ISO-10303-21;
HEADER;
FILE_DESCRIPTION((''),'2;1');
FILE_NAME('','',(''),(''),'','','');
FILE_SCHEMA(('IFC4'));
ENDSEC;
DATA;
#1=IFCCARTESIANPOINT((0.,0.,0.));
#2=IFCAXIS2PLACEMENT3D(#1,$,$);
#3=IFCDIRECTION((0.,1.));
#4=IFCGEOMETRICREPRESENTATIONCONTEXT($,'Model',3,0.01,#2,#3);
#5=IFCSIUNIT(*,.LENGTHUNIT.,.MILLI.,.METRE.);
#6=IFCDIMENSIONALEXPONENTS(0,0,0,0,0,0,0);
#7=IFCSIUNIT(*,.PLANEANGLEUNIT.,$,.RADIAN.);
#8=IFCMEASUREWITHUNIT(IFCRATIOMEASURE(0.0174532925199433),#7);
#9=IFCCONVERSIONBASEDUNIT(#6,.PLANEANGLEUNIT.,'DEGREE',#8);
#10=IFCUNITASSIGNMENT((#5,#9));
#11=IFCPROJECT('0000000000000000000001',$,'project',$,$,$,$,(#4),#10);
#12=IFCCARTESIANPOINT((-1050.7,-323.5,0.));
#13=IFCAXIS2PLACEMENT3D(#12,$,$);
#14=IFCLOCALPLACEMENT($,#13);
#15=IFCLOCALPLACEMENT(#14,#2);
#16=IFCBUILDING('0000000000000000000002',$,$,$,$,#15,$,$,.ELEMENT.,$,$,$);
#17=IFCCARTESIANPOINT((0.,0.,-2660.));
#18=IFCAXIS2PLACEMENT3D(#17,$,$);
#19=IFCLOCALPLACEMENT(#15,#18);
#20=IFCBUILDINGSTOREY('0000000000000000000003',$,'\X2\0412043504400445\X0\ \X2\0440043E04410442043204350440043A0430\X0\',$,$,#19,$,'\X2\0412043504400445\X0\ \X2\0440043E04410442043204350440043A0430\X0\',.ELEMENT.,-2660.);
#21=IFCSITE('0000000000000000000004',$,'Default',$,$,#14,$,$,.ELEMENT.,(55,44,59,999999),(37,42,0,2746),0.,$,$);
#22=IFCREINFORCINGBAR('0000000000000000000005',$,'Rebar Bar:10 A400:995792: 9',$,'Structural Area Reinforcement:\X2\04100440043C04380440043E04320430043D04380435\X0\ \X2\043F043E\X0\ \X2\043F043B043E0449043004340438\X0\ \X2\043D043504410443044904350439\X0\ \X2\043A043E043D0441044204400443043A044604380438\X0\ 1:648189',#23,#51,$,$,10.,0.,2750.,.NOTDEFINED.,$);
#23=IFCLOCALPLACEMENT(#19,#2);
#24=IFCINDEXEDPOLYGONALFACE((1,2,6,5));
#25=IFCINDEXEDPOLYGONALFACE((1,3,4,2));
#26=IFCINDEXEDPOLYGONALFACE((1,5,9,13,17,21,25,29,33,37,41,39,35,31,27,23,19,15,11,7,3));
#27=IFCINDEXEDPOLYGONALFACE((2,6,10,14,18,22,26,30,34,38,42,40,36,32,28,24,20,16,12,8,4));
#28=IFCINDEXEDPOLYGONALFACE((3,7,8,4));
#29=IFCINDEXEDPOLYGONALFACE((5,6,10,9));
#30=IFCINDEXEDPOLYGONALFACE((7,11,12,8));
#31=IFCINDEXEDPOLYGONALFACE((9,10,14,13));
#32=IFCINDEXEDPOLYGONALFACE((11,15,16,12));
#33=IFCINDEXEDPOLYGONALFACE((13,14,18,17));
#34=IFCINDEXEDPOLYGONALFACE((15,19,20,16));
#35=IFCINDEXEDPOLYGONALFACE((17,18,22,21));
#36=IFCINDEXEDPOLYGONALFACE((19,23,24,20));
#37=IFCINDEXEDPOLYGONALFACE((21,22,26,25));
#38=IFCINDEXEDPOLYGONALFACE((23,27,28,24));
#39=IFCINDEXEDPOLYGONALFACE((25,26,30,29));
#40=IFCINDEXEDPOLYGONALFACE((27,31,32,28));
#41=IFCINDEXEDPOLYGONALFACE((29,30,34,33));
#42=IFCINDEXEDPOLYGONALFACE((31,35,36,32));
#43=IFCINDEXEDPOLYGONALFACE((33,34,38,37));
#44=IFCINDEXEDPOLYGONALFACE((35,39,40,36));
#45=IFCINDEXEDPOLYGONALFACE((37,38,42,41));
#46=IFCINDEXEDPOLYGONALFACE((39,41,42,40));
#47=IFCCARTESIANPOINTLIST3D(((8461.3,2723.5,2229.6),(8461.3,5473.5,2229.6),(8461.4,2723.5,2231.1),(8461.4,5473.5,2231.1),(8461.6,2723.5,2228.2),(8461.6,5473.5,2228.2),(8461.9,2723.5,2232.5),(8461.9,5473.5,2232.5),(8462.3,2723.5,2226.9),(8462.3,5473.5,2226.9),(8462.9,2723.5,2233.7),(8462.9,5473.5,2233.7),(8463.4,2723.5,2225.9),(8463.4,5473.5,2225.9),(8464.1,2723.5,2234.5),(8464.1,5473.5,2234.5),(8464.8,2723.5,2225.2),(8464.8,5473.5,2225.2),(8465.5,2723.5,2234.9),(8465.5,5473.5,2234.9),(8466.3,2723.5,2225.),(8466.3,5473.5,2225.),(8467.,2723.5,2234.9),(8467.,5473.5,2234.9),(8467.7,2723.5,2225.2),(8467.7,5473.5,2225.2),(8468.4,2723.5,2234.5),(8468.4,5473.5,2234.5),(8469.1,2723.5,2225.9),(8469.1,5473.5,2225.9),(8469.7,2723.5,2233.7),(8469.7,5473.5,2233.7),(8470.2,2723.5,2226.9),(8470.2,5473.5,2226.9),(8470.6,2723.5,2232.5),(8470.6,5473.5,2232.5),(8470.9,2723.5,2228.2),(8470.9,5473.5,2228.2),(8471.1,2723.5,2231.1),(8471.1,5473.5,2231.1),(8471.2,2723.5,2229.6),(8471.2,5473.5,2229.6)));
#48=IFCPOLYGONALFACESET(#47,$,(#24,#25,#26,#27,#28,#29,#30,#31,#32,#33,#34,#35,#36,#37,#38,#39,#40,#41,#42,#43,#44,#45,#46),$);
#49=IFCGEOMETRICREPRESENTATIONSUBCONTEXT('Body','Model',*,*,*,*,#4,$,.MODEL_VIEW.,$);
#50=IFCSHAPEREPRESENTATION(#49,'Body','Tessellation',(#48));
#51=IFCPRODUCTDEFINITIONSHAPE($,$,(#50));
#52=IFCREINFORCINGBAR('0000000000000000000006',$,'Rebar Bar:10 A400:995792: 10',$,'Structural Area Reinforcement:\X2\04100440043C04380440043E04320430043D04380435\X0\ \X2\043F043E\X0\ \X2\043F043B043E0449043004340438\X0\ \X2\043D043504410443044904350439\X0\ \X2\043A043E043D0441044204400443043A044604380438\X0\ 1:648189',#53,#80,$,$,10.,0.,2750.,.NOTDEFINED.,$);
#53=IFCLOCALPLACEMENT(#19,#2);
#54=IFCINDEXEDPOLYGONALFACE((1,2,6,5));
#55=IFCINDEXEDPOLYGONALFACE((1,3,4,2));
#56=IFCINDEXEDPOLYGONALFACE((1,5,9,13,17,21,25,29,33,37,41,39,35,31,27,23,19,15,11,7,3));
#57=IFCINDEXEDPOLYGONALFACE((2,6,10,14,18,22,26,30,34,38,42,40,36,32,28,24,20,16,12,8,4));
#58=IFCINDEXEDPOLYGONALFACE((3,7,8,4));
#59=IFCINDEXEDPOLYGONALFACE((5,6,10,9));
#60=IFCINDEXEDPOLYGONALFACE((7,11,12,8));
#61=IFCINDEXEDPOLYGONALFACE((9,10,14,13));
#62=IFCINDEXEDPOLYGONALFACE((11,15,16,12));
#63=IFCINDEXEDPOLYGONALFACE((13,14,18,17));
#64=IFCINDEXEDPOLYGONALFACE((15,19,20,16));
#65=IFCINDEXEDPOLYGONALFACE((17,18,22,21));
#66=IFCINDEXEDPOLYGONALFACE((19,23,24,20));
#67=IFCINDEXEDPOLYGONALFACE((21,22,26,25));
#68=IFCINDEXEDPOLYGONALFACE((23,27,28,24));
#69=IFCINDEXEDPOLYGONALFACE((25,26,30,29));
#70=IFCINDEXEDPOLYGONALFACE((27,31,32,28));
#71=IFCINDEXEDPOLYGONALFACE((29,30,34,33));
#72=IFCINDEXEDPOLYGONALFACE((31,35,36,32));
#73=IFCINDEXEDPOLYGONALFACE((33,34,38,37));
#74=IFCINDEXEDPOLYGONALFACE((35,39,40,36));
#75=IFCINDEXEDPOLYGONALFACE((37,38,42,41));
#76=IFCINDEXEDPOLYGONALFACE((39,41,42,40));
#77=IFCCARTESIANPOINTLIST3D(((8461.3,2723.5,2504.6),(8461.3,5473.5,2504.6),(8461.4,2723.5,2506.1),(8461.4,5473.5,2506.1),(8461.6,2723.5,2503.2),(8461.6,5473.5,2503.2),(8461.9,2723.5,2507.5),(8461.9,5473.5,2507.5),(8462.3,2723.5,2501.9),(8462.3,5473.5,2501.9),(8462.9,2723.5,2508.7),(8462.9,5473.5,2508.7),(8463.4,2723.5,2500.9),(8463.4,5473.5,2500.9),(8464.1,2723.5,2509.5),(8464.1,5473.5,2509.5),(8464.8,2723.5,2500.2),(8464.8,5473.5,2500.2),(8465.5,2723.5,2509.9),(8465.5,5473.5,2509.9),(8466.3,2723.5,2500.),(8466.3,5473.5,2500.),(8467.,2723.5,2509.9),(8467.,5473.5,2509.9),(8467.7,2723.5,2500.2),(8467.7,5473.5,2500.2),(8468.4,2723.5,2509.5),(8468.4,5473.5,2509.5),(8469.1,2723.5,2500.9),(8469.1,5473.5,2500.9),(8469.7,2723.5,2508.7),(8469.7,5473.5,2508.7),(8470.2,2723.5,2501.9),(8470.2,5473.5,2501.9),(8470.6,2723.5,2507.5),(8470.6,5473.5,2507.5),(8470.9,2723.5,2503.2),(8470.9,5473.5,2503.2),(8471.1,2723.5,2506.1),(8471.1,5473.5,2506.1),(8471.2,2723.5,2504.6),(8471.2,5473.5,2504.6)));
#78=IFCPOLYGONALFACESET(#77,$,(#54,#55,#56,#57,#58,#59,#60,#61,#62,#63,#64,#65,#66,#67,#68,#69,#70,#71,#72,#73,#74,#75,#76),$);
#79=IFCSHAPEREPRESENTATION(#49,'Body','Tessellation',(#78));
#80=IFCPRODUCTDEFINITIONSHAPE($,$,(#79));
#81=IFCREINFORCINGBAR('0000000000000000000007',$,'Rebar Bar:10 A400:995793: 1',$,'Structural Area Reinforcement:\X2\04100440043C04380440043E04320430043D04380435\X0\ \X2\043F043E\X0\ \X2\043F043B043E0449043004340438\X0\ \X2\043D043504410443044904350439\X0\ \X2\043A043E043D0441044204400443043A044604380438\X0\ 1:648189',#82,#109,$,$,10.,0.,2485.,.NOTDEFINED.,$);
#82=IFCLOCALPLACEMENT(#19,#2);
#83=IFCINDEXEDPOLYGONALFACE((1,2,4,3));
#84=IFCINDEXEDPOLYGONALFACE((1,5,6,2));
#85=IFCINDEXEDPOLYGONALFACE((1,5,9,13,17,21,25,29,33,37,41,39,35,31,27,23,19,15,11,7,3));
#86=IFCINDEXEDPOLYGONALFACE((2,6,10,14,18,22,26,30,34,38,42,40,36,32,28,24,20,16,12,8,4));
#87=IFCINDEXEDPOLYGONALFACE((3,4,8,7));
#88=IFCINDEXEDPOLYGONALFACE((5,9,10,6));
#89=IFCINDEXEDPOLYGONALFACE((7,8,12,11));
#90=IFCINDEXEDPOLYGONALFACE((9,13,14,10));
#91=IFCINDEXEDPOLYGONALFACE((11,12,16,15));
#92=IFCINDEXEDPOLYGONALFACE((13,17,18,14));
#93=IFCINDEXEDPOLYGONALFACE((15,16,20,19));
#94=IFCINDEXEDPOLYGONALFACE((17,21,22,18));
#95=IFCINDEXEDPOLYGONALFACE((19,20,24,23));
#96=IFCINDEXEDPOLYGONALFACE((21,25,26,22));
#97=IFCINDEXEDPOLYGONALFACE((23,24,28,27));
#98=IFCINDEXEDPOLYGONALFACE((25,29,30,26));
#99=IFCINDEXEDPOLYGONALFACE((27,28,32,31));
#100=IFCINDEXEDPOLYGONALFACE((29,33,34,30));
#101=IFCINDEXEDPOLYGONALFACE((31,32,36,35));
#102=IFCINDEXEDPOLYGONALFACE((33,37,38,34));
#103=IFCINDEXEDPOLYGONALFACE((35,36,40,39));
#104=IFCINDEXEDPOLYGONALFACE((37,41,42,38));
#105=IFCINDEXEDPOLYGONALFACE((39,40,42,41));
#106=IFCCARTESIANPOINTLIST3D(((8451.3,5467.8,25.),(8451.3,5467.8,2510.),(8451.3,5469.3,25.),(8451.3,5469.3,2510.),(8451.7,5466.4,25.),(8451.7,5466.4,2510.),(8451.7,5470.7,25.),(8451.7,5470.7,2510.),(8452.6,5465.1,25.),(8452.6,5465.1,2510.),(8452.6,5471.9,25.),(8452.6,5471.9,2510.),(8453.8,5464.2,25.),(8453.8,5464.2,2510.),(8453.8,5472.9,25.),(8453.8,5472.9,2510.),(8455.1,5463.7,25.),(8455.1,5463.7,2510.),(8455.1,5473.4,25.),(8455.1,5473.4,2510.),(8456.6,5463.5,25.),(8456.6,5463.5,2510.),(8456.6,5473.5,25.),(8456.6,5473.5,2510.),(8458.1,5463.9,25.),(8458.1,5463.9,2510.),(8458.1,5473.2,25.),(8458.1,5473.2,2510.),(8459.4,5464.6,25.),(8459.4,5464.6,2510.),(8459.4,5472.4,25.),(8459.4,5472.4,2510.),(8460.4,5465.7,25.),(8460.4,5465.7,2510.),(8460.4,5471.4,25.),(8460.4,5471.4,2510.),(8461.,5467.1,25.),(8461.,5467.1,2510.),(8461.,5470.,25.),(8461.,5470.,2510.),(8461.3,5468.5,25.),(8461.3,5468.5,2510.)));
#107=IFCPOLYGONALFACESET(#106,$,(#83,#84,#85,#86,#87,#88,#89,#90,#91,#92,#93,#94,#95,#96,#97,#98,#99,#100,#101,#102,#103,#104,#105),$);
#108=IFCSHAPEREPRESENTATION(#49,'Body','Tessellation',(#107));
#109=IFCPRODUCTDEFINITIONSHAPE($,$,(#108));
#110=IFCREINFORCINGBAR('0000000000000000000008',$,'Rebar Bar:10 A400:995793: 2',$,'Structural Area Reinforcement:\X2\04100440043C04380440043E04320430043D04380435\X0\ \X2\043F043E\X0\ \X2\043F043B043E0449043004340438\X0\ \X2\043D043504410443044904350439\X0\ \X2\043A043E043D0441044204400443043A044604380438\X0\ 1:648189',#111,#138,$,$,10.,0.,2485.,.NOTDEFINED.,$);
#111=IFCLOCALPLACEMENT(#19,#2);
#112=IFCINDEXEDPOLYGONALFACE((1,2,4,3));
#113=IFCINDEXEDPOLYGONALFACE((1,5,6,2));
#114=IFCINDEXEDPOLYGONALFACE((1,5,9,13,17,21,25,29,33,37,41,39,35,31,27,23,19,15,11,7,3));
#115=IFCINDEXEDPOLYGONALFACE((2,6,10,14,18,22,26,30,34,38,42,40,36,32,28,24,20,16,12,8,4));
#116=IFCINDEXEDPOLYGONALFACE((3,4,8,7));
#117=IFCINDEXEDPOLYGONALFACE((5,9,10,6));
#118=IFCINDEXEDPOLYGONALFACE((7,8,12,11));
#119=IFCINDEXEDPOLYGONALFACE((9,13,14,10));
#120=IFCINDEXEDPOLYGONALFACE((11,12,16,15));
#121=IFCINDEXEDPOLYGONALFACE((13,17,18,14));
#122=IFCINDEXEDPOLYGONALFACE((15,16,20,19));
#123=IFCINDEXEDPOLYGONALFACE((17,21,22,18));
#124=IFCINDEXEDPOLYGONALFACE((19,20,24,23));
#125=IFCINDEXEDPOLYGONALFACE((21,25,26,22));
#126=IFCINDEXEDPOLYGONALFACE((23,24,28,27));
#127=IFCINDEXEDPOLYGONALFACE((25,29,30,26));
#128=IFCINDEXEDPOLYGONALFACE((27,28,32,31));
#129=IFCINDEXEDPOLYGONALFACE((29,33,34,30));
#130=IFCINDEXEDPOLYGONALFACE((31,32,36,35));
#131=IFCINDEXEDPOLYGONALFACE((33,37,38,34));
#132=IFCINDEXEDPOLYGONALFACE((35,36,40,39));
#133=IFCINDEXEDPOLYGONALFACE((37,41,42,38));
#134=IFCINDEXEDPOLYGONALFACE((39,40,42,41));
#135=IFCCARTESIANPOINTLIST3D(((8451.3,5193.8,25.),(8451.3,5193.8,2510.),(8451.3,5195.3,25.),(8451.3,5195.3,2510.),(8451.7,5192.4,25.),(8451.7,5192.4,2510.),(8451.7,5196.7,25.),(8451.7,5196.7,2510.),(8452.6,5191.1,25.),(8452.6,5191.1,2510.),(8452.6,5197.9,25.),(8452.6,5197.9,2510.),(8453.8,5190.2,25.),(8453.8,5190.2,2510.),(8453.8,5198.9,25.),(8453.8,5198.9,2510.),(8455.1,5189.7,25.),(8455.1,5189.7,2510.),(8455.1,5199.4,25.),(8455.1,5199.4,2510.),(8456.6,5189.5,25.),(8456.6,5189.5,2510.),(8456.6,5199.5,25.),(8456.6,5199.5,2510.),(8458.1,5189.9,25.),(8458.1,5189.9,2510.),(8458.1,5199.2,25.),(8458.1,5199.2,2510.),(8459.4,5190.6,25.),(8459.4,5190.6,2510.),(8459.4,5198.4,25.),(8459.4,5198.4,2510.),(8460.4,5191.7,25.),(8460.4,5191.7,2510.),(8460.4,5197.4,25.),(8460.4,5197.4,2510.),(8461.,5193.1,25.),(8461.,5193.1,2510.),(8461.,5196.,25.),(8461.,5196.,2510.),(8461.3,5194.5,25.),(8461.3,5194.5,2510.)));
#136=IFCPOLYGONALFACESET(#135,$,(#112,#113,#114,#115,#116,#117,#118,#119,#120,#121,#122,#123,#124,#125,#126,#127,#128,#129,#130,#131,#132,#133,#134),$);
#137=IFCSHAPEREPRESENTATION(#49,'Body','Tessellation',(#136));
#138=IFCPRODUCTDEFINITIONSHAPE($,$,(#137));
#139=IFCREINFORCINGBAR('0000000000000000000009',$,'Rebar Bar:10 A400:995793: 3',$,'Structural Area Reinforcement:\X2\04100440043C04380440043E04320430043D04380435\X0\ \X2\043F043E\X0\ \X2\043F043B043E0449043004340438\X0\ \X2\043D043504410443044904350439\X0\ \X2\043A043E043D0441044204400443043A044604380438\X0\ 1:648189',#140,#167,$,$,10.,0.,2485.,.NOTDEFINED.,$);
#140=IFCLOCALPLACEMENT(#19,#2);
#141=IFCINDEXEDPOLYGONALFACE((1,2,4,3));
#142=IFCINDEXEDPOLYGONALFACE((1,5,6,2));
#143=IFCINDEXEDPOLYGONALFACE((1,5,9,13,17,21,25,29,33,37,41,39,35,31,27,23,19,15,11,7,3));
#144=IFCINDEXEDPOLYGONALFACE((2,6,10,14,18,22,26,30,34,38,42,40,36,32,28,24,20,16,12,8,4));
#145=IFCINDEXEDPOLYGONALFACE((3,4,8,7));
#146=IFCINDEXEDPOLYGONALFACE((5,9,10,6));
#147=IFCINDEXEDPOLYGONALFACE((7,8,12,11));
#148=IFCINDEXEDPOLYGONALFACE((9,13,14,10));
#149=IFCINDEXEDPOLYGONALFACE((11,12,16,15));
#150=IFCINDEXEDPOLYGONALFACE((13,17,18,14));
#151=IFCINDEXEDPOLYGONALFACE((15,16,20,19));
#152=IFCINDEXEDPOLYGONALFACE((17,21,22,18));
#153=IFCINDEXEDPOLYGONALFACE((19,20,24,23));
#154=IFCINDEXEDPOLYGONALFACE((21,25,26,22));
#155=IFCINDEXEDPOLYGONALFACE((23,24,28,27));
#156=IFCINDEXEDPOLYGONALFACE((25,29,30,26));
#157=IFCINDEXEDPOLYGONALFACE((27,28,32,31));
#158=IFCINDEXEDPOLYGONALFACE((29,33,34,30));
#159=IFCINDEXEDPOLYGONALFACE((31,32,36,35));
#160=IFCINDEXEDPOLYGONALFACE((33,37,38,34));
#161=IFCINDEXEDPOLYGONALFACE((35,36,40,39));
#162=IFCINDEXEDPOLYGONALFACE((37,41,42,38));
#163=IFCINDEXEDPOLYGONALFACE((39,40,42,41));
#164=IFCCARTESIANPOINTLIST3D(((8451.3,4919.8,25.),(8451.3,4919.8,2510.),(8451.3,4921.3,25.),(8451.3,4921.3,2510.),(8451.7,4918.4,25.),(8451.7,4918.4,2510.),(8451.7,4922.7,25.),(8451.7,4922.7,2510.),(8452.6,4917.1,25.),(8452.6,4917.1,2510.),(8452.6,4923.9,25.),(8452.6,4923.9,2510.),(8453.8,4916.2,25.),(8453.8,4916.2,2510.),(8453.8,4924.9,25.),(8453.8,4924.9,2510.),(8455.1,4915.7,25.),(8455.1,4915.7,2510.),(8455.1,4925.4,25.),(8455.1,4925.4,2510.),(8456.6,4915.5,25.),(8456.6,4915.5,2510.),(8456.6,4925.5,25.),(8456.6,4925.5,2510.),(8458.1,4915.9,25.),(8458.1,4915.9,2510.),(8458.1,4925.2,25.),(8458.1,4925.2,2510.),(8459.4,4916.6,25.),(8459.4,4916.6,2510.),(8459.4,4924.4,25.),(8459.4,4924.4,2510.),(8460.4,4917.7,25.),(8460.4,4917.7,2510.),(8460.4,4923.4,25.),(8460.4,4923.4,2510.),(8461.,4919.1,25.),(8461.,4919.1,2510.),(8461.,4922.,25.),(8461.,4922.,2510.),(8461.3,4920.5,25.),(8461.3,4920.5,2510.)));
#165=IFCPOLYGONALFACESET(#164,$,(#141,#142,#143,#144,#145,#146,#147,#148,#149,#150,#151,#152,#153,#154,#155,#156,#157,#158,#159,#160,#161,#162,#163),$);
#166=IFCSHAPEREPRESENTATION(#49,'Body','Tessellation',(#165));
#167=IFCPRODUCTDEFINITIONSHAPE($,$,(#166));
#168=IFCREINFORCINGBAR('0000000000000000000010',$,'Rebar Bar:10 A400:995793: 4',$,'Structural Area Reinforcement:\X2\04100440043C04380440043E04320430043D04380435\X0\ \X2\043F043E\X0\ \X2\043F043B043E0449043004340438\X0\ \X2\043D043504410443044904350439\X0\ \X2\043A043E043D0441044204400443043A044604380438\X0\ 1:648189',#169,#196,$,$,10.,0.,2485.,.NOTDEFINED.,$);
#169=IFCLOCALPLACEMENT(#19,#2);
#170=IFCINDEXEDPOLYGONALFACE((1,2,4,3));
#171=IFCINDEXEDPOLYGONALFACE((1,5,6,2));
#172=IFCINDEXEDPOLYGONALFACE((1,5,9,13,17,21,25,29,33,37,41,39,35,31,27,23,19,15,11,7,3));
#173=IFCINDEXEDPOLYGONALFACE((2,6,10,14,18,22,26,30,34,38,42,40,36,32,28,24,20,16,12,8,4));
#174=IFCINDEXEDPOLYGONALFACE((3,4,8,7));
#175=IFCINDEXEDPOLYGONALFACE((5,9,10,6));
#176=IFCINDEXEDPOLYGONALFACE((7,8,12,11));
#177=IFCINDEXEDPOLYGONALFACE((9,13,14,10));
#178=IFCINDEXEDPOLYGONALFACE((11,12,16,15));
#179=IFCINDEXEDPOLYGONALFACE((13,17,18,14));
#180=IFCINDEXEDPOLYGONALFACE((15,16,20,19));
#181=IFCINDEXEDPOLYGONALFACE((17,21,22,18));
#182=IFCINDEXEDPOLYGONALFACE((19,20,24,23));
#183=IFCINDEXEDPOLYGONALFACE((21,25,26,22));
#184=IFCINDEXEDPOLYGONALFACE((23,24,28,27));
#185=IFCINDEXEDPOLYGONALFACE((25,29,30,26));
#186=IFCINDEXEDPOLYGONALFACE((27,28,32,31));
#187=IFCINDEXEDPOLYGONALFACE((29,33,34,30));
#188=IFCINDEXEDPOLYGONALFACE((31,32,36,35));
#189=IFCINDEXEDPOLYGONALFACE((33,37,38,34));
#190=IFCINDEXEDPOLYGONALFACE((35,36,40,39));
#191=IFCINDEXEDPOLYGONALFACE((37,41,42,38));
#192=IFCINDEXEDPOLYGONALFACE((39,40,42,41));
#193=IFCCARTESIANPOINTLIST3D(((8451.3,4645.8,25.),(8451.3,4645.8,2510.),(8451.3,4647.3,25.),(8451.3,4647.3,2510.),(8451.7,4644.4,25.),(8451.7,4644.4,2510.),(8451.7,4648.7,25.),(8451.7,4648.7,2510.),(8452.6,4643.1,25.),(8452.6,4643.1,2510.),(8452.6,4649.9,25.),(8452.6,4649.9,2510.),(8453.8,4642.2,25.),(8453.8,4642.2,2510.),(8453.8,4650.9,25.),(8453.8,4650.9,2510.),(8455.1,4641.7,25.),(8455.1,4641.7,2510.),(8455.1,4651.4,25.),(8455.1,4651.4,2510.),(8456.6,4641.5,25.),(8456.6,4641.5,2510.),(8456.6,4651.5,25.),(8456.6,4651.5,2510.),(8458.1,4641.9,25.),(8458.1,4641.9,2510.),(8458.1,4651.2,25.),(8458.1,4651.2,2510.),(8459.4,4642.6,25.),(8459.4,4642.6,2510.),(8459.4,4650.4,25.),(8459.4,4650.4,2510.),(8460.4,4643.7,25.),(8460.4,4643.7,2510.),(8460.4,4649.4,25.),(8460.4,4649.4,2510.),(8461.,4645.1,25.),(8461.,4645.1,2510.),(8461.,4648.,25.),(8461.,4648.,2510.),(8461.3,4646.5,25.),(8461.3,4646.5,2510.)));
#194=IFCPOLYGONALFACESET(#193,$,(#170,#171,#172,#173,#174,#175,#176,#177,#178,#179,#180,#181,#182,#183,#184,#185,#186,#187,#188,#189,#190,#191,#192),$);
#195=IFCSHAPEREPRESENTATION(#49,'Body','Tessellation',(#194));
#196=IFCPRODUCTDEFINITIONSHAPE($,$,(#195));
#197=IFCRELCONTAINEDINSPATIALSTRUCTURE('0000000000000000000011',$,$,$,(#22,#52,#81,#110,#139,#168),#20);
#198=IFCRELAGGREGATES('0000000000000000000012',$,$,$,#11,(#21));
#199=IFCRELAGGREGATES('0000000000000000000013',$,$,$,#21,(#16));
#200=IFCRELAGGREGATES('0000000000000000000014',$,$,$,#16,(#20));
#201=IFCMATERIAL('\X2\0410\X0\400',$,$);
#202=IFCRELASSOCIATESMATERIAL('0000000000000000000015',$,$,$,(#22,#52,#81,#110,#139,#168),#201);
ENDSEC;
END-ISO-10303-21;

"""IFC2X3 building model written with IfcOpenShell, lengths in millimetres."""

from ifc_helpers import new_model, entity, si_unit, converted_unit, direction, frame, origin, place, context, subcontext, project, spatial, material, element, save


model = new_model("IFC2X3")

# Units and contexts
model_context = context("Model", 3, precision=0.01, world=origin(), true_north=direction((0.0, 1.0)))
body_context = subcontext(model_context, "Body", "Model", "MODEL_VIEW")
ifc_project = project(units=[si_unit("LENGTHUNIT", "METRE", prefix="MILLI"), converted_unit("PLANEANGLEUNIT", "DEGREE", entity("IfcRatioMeasure", 0.0174532925199433), si_unit("PLANEANGLEUNIT", "RADIAN"), dimensions=[0, 0, 0, 0, 0, 0, 0])], contexts=[model_context])

# Site, building, storey
site_placement = place(None, frame((-1050.7, -323.5, 0.0)))
site = spatial("IfcSite", under=ifc_project, at=site_placement, Name="Default", CompositionType="ELEMENT", RefLatitude=(55, 44, 59, 999999), RefLongitude=(37, 42, 0, 2746), RefElevation=0.0)
building_placement = place(site_placement, origin())
building = spatial("IfcBuilding", under=site, at=building_placement, CompositionType="ELEMENT")
storey_placement = place(building_placement, frame((0.0, 0.0, -2660.0)))
storey = spatial("IfcBuildingStorey", under=building, at=storey_placement, Name="Верх ростверка", LongName="Верх ростверка", CompositionType="ELEMENT", Elevation=-2660.0)

# Reinforcing bars
ifc_material = material(Name="А400")
reinforcing_bar_1_placement = place(storey_placement, origin())
element("IfcReinforcingBar", 1, at=reinforcing_bar_1_placement, inside=storey, material=ifc_material, Name="Rebar Bar:10 A400:995792: 9", ObjectType="Structural Area Reinforcement:Армирование по площади несущей конструкции 1:648189", BarLength=2750.0, BarRole="NOTDEFINED", CrossSectionArea=0.0, NominalDiameter=10.0, context=body_context, shape_type="AdvancedSweptSolid", body=[
    entity("IfcSweptDiskSolid", entity("IfcCompositeCurve", [entity("IfcCompositeCurveSegment", "CONTINUOUS", True, entity("IfcPolyline", [entity("IfcCartesianPoint", [8466.3, 5473.5, 2230.0]), entity("IfcCartesianPoint", [8466.3, 2723.5, 2230.0])]))], False), 5.0, None, 0.0, 1.0),
])
reinforcing_bar_2_placement = place(storey_placement, origin())
element("IfcReinforcingBar", 2, at=reinforcing_bar_2_placement, inside=storey, material=ifc_material, Name="Rebar Bar:10 A400:995792: 10", ObjectType="Structural Area Reinforcement:Армирование по площади несущей конструкции 1:648189", BarLength=2750.0, BarRole="NOTDEFINED", CrossSectionArea=0.0, NominalDiameter=10.0, context=body_context, shape_type="AdvancedSweptSolid", body=[
    entity("IfcSweptDiskSolid", entity("IfcCompositeCurve", [entity("IfcCompositeCurveSegment", "CONTINUOUS", True, entity("IfcPolyline", [entity("IfcCartesianPoint", [8466.3, 5473.5, 2505.0]), entity("IfcCartesianPoint", [8466.3, 2723.5, 2505.0])]))], False), 5.0, None, 0.0, 1.0),
])
reinforcing_bar_3_placement = place(storey_placement, origin())
element("IfcReinforcingBar", 3, at=reinforcing_bar_3_placement, inside=storey, material=ifc_material, Name="Rebar Bar:10 A400:995793: 1", ObjectType="Structural Area Reinforcement:Армирование по площади несущей конструкции 1:648189", BarLength=2485.0, BarRole="NOTDEFINED", CrossSectionArea=0.0, NominalDiameter=10.0, context=body_context, shape_type="AdvancedSweptSolid", body=[
    entity("IfcSweptDiskSolid", entity("IfcCompositeCurve", [entity("IfcCompositeCurveSegment", "CONTINUOUS", True, entity("IfcPolyline", [entity("IfcCartesianPoint", [8456.3, 5468.5, 25.0]), entity("IfcCartesianPoint", [8456.3, 5468.5, 2510.0])]))], False), 5.0, None, 0.0, 1.0),
])
reinforcing_bar_4_placement = place(storey_placement, origin())
element("IfcReinforcingBar", 4, at=reinforcing_bar_4_placement, inside=storey, material=ifc_material, Name="Rebar Bar:10 A400:995793: 2", ObjectType="Structural Area Reinforcement:Армирование по площади несущей конструкции 1:648189", BarLength=2485.0, BarRole="NOTDEFINED", CrossSectionArea=0.0, NominalDiameter=10.0, context=body_context, shape_type="AdvancedSweptSolid", body=[
    entity("IfcSweptDiskSolid", entity("IfcCompositeCurve", [entity("IfcCompositeCurveSegment", "CONTINUOUS", True, entity("IfcPolyline", [entity("IfcCartesianPoint", [8456.3, 5194.5, 25.0]), entity("IfcCartesianPoint", [8456.3, 5194.5, 2510.0])]))], False), 5.0, None, 0.0, 1.0),
])
reinforcing_bar_5_placement = place(storey_placement, origin())
element("IfcReinforcingBar", 5, at=reinforcing_bar_5_placement, inside=storey, material=ifc_material, Name="Rebar Bar:10 A400:995793: 3", ObjectType="Structural Area Reinforcement:Армирование по площади несущей конструкции 1:648189", BarLength=2485.0, BarRole="NOTDEFINED", CrossSectionArea=0.0, NominalDiameter=10.0, context=body_context, shape_type="AdvancedSweptSolid", body=[
    entity("IfcSweptDiskSolid", entity("IfcCompositeCurve", [entity("IfcCompositeCurveSegment", "CONTINUOUS", True, entity("IfcPolyline", [entity("IfcCartesianPoint", [8456.3, 4920.5, 25.0]), entity("IfcCartesianPoint", [8456.3, 4920.5, 2510.0])]))], False), 5.0, None, 0.0, 1.0),
])
reinforcing_bar_6_placement = place(storey_placement, origin())
element("IfcReinforcingBar", 6, at=reinforcing_bar_6_placement, inside=storey, material=ifc_material, Name="Rebar Bar:10 A400:995793: 4", ObjectType="Structural Area Reinforcement:Армирование по площади несущей конструкции 1:648189", BarLength=2485.0, BarRole="NOTDEFINED", CrossSectionArea=0.0, NominalDiameter=10.0, context=body_context, shape_type="AdvancedSweptSolid", body=[
    entity("IfcSweptDiskSolid", entity("IfcCompositeCurve", [entity("IfcCompositeCurveSegment", "CONTINUOUS", True, entity("IfcPolyline", [entity("IfcCartesianPoint", [8456.3, 4646.5, 25.0]), entity("IfcCartesianPoint", [8456.3, 4646.5, 2510.0])]))], False), 5.0, None, 0.0, 1.0),
])

save(model, "model.ifc")
